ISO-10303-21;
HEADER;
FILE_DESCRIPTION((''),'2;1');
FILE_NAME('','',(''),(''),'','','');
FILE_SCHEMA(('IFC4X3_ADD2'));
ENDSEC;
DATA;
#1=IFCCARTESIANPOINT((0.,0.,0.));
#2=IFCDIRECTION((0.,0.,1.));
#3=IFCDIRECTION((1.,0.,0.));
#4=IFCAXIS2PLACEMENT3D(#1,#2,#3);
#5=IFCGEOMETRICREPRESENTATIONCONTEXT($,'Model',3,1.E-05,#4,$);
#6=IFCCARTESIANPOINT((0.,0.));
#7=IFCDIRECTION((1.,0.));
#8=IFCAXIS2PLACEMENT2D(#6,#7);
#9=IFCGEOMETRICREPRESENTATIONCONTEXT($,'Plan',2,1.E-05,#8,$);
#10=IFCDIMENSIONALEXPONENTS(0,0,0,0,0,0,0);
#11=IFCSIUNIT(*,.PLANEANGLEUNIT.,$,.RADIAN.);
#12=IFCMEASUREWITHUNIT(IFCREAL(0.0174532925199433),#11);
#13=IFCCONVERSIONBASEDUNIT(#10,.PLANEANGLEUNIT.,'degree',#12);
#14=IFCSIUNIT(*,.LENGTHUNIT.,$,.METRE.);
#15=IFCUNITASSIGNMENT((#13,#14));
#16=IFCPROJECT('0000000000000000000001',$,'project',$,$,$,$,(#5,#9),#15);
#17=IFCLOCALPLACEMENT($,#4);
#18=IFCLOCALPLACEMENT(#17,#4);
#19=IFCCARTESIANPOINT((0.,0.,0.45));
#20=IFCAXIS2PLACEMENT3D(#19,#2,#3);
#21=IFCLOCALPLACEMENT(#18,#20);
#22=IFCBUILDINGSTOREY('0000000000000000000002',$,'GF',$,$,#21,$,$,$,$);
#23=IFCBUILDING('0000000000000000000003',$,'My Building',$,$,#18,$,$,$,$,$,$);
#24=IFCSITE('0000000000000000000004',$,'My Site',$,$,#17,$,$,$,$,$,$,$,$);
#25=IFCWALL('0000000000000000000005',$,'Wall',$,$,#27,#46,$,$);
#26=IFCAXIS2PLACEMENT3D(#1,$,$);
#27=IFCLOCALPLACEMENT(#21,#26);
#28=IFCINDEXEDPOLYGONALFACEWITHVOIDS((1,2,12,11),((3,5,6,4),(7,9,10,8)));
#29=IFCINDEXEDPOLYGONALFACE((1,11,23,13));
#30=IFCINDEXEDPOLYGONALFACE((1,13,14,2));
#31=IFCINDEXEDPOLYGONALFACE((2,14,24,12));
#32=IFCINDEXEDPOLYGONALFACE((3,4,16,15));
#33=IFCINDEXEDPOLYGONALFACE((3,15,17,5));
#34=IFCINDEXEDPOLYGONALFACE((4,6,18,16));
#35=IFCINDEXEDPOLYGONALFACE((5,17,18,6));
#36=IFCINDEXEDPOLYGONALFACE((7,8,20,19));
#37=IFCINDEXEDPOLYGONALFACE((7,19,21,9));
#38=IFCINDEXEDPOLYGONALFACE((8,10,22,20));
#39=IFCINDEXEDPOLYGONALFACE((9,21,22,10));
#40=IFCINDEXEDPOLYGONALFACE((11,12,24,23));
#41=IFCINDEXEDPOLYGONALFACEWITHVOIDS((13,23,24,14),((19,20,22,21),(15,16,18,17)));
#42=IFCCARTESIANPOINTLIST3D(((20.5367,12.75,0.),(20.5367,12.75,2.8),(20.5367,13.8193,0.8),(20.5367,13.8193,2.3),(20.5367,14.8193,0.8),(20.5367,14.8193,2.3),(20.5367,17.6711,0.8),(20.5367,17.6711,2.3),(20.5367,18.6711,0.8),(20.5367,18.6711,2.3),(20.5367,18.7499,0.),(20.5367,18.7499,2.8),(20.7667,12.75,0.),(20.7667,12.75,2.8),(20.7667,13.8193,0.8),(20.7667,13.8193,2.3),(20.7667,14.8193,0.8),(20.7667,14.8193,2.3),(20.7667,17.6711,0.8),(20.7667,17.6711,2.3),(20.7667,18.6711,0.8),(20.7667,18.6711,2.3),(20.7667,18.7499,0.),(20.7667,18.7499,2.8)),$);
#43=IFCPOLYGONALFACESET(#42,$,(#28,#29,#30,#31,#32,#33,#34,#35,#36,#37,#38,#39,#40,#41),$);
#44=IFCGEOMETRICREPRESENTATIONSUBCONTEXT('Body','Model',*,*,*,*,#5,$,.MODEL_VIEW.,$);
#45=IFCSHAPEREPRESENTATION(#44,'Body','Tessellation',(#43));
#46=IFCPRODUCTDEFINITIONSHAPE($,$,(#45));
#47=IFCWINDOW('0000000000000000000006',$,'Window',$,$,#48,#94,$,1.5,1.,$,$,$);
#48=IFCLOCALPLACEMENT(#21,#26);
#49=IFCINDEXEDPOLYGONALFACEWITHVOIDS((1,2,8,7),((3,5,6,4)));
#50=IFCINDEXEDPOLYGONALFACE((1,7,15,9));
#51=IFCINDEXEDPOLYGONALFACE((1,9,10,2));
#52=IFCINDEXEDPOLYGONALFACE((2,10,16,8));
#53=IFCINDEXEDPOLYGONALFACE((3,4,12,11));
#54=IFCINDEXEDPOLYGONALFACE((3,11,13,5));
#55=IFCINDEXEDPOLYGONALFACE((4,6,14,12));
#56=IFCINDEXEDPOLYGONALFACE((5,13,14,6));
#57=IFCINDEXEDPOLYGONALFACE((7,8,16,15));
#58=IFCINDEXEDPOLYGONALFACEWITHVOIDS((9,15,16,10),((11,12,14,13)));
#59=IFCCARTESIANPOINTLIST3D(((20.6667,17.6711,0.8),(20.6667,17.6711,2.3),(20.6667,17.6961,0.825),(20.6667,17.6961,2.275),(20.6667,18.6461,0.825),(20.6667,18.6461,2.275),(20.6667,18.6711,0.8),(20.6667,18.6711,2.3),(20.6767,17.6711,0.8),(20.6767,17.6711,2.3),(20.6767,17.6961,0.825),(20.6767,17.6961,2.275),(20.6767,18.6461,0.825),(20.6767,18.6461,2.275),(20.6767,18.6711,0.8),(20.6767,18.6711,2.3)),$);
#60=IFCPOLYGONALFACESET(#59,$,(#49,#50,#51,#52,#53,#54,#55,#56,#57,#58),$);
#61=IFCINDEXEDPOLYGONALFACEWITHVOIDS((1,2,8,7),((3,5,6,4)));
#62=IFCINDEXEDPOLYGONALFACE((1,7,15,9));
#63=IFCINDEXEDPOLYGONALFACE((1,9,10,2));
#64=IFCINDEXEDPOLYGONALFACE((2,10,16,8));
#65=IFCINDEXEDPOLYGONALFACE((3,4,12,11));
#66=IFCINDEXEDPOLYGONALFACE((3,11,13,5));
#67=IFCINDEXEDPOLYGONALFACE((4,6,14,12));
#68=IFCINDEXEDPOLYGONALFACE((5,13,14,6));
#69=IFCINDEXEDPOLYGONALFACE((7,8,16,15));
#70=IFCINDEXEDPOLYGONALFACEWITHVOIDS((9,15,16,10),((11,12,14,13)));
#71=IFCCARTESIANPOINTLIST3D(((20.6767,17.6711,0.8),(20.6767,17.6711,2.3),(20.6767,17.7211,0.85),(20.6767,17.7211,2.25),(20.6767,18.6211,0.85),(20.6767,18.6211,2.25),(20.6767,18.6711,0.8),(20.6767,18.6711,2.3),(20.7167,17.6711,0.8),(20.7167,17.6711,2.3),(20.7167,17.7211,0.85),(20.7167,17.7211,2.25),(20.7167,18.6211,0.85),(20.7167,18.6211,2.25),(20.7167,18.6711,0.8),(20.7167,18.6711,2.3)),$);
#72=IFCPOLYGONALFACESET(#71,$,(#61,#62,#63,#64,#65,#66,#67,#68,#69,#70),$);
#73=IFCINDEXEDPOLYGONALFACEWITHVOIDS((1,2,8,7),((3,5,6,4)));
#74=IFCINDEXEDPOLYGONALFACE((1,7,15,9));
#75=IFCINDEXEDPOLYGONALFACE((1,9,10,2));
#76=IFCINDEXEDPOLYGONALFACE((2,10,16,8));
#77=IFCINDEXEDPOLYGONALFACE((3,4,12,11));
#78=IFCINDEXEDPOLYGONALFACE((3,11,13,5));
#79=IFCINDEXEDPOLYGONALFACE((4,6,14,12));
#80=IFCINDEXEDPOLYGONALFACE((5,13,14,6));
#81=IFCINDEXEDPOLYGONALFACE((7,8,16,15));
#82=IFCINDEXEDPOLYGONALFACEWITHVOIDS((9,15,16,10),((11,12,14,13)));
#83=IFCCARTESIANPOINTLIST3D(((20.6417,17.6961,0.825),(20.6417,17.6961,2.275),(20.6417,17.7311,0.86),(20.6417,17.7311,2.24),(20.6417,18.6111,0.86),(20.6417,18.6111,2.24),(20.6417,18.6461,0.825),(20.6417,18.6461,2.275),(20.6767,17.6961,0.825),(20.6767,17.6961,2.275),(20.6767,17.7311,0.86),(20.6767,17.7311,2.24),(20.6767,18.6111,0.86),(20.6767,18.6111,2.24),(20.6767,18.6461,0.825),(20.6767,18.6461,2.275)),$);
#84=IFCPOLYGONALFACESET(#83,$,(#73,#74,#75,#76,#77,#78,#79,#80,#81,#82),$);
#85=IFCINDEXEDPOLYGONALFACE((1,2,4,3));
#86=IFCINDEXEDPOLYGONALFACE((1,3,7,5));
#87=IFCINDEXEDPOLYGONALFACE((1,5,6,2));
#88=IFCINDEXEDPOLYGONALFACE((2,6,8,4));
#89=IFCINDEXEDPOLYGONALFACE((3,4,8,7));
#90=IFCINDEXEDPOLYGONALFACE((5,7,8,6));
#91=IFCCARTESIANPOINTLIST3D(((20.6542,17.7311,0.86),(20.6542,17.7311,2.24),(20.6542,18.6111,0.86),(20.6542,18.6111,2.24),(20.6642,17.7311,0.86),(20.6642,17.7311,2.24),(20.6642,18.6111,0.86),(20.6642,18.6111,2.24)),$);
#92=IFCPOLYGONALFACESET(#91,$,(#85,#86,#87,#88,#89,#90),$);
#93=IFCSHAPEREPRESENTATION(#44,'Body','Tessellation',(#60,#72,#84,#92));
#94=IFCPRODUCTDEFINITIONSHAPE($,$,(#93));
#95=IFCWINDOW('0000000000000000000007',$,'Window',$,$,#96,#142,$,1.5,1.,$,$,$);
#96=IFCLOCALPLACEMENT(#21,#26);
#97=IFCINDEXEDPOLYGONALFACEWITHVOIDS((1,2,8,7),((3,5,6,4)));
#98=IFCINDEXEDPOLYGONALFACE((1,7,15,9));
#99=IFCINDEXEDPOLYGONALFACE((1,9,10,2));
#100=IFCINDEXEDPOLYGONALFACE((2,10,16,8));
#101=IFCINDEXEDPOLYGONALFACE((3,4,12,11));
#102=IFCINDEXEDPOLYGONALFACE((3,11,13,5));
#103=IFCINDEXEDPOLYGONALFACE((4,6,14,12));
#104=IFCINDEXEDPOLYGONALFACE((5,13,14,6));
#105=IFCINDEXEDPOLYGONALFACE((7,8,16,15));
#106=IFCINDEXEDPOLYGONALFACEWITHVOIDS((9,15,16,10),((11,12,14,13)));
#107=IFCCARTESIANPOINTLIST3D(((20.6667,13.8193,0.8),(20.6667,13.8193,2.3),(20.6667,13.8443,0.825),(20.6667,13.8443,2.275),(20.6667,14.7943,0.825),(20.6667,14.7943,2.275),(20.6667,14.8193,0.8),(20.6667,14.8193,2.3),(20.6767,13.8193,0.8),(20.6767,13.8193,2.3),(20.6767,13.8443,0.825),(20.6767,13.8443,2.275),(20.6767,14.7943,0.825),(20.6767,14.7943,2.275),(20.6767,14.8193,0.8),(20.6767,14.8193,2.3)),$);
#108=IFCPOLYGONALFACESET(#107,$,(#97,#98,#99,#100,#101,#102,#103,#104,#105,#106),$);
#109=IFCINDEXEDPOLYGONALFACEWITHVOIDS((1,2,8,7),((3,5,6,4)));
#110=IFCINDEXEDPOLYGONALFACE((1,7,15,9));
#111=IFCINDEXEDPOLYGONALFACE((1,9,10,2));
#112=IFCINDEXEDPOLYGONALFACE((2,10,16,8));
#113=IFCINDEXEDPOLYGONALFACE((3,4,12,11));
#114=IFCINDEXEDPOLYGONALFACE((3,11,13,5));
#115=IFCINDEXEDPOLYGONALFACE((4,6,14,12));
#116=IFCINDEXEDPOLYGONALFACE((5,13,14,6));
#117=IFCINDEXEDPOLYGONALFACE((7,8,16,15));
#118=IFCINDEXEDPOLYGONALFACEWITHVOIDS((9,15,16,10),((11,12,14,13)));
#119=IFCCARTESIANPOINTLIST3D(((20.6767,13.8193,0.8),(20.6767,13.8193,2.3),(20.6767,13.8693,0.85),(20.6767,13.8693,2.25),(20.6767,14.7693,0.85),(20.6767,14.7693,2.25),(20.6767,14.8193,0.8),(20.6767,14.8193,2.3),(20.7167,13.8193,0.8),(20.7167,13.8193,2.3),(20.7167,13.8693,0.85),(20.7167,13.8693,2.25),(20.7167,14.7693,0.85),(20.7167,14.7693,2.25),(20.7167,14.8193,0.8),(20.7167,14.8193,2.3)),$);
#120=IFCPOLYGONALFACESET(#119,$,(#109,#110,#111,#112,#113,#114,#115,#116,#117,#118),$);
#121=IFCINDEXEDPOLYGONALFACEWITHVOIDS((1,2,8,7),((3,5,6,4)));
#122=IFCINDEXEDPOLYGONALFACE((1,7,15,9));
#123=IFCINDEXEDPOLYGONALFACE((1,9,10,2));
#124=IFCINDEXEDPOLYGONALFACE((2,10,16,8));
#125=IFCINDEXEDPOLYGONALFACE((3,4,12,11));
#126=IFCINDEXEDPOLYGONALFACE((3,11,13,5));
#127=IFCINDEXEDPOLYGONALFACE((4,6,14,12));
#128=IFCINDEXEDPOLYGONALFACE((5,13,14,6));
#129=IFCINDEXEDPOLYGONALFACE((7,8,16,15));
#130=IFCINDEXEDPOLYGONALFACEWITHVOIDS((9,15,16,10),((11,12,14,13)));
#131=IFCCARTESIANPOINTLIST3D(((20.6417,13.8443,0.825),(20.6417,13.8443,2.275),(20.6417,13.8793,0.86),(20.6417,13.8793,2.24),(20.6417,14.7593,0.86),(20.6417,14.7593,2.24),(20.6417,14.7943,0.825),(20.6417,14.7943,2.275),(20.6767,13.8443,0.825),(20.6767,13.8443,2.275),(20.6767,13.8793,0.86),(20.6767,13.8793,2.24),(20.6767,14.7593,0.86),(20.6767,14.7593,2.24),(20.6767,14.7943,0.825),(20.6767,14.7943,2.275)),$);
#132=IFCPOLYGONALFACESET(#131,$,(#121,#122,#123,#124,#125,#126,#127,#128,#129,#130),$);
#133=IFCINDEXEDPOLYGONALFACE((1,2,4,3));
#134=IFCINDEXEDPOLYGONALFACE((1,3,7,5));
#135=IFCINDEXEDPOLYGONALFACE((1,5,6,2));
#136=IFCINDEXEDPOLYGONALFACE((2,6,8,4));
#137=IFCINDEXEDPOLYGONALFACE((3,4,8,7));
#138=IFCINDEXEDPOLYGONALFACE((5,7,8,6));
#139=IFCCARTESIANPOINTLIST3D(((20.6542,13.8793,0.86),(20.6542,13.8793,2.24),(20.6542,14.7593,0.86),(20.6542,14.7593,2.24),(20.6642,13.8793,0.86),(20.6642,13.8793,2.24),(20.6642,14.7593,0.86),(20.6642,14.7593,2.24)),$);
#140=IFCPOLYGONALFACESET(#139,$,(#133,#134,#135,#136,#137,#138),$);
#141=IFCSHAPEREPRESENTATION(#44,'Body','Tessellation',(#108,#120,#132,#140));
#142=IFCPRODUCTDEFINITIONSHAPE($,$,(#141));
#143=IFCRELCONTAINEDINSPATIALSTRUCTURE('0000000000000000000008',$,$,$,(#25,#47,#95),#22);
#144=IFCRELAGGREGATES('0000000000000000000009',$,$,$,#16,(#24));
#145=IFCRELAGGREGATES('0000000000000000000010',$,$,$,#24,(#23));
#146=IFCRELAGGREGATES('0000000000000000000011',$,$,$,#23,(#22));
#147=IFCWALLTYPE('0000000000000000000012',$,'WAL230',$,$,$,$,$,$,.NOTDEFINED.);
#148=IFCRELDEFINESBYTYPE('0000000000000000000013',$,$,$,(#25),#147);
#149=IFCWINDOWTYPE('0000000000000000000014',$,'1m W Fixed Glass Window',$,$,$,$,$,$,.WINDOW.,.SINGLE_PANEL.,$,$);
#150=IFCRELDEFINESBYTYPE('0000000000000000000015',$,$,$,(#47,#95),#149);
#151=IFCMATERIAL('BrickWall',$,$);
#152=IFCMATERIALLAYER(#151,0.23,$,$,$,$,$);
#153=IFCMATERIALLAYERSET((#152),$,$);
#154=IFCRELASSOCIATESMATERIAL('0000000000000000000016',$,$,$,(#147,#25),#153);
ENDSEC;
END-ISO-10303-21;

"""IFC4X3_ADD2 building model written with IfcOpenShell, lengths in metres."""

from ifc_helpers import new_model, entity, si_unit, converted_unit, frame, origin_with_axes, origin_2d_with_axis, place, context, subcontext, project, spatial, line, indexed_curve, outline, extrude, shape, source, transform, mapped, material, layer, layer_set, layer_usage, type_object, type_shapes, element, fill, save


model = new_model("IFC4X3_ADD2")

# Units and contexts
model_context = context("Model", 3, precision=1e-05, world=origin_with_axes())
plan_context = context("Plan", 2, precision=1e-05, world=origin_2d_with_axis())
body_context_1 = subcontext(model_context, "Body", "Model", "MODEL_VIEW")
body_context_2 = subcontext(plan_context, "Body", "Plan", "PLAN_VIEW")
ifc_project = project(units=[converted_unit("PLANEANGLEUNIT", "degree", entity("IfcReal", 0.0174532925199433), si_unit("PLANEANGLEUNIT", "RADIAN"), dimensions=[0, 0, 0, 0, 0, 0, 0]), si_unit("LENGTHUNIT", "METRE")], contexts=[model_context, plan_context])

# Site, building, storey
site_placement = place(None, origin_with_axes())
site = spatial("IfcSite", under=ifc_project, at=site_placement, Name="My Site")
building_placement = place(site_placement, origin_with_axes())
building = spatial("IfcBuilding", under=site, at=building_placement, Name="My Building")
storey_placement = place(building_placement, frame((0.0, 0.0, 0.45), z_axis=(0.0, 0.0, 1.0), x_axis=(1.0, 0.0, 0.0)))
storey = spatial("IfcBuildingStorey", under=building, at=storey_placement, Name="GF")

# Shared definitions
ifc_material_1 = material(Name="BrickWall")
ifc_layer_1 = layer(ifc_material_1, 0.23)
ifc_layer_set_1 = layer_set([ifc_layer_1])
wall_type_1 = type_object("IfcWallType", Name="WAL230", PredefinedType="NOTDEFINED", material=ifc_layer_set_1)

# Wall, openings, windows
ifc_layer_usage_1 = layer_usage(ifc_layer_set_1, "AXIS2", "POSITIVE", 0.0)
wall_1_placement = place(storey_placement, frame((20.7667, 12.75, 0.0), z_axis=(0.0, 0.0, 1.0), x_axis=(0.0, 1.0, 0.0)))
wall_1 = element("IfcWall", 1, at=wall_1_placement, inside=storey, type_object=wall_type_1, material=ifc_layer_usage_1, Name="Wall", context=body_context_1, shape_type="SweptSolid", body=[
    extrude(outline(indexed_curve([(0.0, 0.0), (0.0, 0.23), (5.9999, 0.23), (5.9999, 0.0), (0.0, 0.0)], self_intersect=False)), origin_with_axes(), (0.0, 0.0, 1.0), 2.8),
])
shared_shape_1 = source(origin_with_axes(), body_context_1, "Body", "SweptSolid", [
    extrude(outline(indexed_curve([(0.0, 0.0), (1.0, 0.0), (1.0, 1.5), (0.0, 1.5)], segments=[line(1, 2, 3, 4, 1)])), frame((0.0, -0.6, 0.0), z_axis=(0.0, -1.0, 0.0), x_axis=(1.0, 0.0, 0.0)), (0.0, 0.0, -1.0), 1.2),
])
opening_1_placement = place(wall_1_placement, frame((4.9211, 0.0, 0.8), z_axis=(0.0, 0.0, 1.0), x_axis=(1.0, 0.0, 0.0)))
opening_1 = element("IfcOpeningElement", 2, at=opening_1_placement, cuts=wall_1, PredefinedType="OPENING", context=body_context_1, shape_type="MappedRepresentation", body=[
    mapped(shared_shape_1, transform((0.0, 0.0, 0.0), x_axis=(1.0, 0.0, 0.0), y_axis=(0.0, 1.0, 0.0), z_axis=(0.0, 0.0, 1.0), scale=1.0)),
])
opening_2_placement = place(wall_1_placement, frame((1.0693, 0.0, 0.8), z_axis=(0.0, 0.0, 1.0), x_axis=(1.0, 0.0, 0.0)))
opening_2 = element("IfcOpeningElement", 3, at=opening_2_placement, cuts=wall_1, PredefinedType="OPENING", context=body_context_1, shape_type="MappedRepresentation", body=[
    mapped(shared_shape_1, transform((0.0, 0.0, 0.0), x_axis=(1.0, 0.0, 0.0), y_axis=(0.0, 1.0, 0.0), z_axis=(0.0, 0.0, 1.0), scale=1.0)),
])
window_type_1 = type_object("IfcWindowType", Name="1m W Fixed Glass Window", PartitioningType="SINGLE_PANEL", PredefinedType="WINDOW")
shared_shape_2 = source(origin_with_axes(), body_context_1, "Body", "SweptSolid", [
    extrude(outline(indexed_curve([(0.0, 0.0), (1.0, 0.0), (1.0, 1.5), (0.0, 1.5)], segments=[line(1, 2, 3, 4, 1)]), holes=[indexed_curve([(0.025, 0.025), (0.975, 0.025), (0.975, 1.475), (0.025, 1.475)], segments=[line(1, 2, 3, 4, 1)])]), frame((0.0, 0.09, 0.0), z_axis=(0.0, -1.0, 0.0), x_axis=(1.0, 0.0, 0.0)), (0.0, 0.0, -1.0), 0.01),
    extrude(outline(indexed_curve([(0.0, 0.0), (1.0, 0.0), (1.0, 1.5), (0.0, 1.5)], segments=[line(1, 2, 3, 4, 1)]), holes=[indexed_curve([(0.05, 0.05), (0.95, 0.05), (0.95, 1.45), (0.05, 1.45)], segments=[line(1, 2, 3, 4, 1)])]), frame((0.0, 0.05, 0.0), z_axis=(0.0, -1.0, 0.0), x_axis=(1.0, 0.0, 0.0)), (0.0, 0.0, -1.0), 0.04),
    extrude(outline(indexed_curve([(0.0, 0.0), (0.95, 0.0), (0.95, 1.45), (0.0, 1.45)], segments=[line(1, 2, 3, 4, 1)]), holes=[indexed_curve([(0.035, 0.035), (0.915, 0.035), (0.915, 1.415), (0.035, 1.415)], segments=[line(1, 2, 3, 4, 1)])]), frame((0.025, 0.09, 0.025), z_axis=(0.0, -1.0, 0.0), x_axis=(1.0, 0.0, 0.0)), (0.0, 0.0, -1.0), 0.035),
    extrude(outline(indexed_curve([(0.035, 0.035), (0.915, 0.035), (0.915, 1.415), (0.035, 1.415)], segments=[line(1, 2, 3, 4, 1)])), frame((0.025, 0.1025, 0.025), z_axis=(0.0, -1.0, 0.0), x_axis=(1.0, 0.0, 0.0)), (0.0, 0.0, -1.0), 0.01),
])
shared_shape_3 = source(origin_with_axes(), body_context_2, "Body", "Curve2D", [
    entity("IfcIndexedPolyCurve", entity("IfcCartesianPointList2D", [[0.05, 0.05], [0.95, 0.05]])),
    entity("IfcIndexedPolyCurve", entity("IfcCartesianPointList2D", [[0.0, 0.1], [0.025, 0.1], [0.025, 0.09], [0.05, 0.09], [0.05, 0.05], [0.0, 0.05]]), [entity("IfcLineIndex", [1, 2, 3, 4, 5, 6, 1])]),
    entity("IfcIndexedPolyCurve", entity("IfcCartesianPointList2D", [[1.0, 0.1], [0.975, 0.1], [0.975, 0.09], [0.95, 0.09], [0.95, 0.05], [1.0, 0.05]]), [entity("IfcLineIndex", [1, 2, 3, 4, 5, 6, 1])]),
    entity("IfcIndexedPolyCurve", entity("IfcCartesianPointList2D", [[0.025, 0.09], [0.06, 0.09], [0.06, 0.125], [0.025, 0.125]]), [entity("IfcLineIndex", [1, 2, 3, 4, 1])]),
    entity("IfcIndexedPolyCurve", entity("IfcCartesianPointList2D", [[0.975, 0.09], [0.94, 0.09], [0.94, 0.125], [0.975, 0.125]]), [entity("IfcLineIndex", [1, 2, 3, 4, 1])]),
    entity("IfcIndexedPolyCurve", entity("IfcCartesianPointList2D", [[0.06, 0.09], [0.94, 0.09]])),
    entity("IfcIndexedPolyCurve", entity("IfcCartesianPointList2D", [[0.06, 0.125], [0.94, 0.125]])),
    entity("IfcIndexedPolyCurve", entity("IfcCartesianPointList2D", [[0.06, 0.1075], [0.94, 0.1075]])),
])
type_shapes(window_type_1, [shared_shape_2, shared_shape_3])
window_1_placement = place(opening_1_placement, frame((0.0, 0.0, 0.0), z_axis=(0.0, 0.0, 1.0), x_axis=(1.0, 0.0, 0.0)))
window_1 = element("IfcWindow", 4, at=window_1_placement, inside=storey, type_object=window_type_1, Name="Window", OverallHeight=1.5, OverallWidth=1.0, shapes=[
    shape(body_context_1, "Body", "MappedRepresentation", [mapped(shared_shape_2, transform((0.0, 0.0, 0.0), x_axis=(1.0, 0.0, 0.0), y_axis=(0.0, 1.0, 0.0), z_axis=(0.0, 0.0, 1.0), scale=1.0))]),
    shape(body_context_2, "Body", "MappedRepresentation", [mapped(shared_shape_3, transform((0.0, 0.0, 0.0), x_axis=(1.0, 0.0, 0.0), y_axis=(0.0, 1.0, 0.0), z_axis=(0.0, 0.0, 1.0), scale=1.0))]),
])
fill(opening_1, window_1)
window_2_placement = place(opening_2_placement, frame((0.0, 0.0, 0.0), z_axis=(0.0, 0.0, 1.0), x_axis=(1.0, 0.0, 0.0)))
window_2 = element("IfcWindow", 5, at=window_2_placement, inside=storey, type_object=window_type_1, Name="Window", OverallHeight=1.5, OverallWidth=1.0, shapes=[
    shape(body_context_1, "Body", "MappedRepresentation", [mapped(shared_shape_2, transform((0.0, 0.0, 0.0), x_axis=(1.0, 0.0, 0.0), y_axis=(0.0, 1.0, 0.0), z_axis=(0.0, 0.0, 1.0), scale=1.0))]),
    shape(body_context_2, "Body", "MappedRepresentation", [mapped(shared_shape_3, transform((0.0, 0.0, 0.0), x_axis=(1.0, 0.0, 0.0), y_axis=(0.0, 1.0, 0.0), z_axis=(0.0, 0.0, 1.0), scale=1.0))]),
])
fill(opening_2, window_2)

save(model, "model.ifc")
